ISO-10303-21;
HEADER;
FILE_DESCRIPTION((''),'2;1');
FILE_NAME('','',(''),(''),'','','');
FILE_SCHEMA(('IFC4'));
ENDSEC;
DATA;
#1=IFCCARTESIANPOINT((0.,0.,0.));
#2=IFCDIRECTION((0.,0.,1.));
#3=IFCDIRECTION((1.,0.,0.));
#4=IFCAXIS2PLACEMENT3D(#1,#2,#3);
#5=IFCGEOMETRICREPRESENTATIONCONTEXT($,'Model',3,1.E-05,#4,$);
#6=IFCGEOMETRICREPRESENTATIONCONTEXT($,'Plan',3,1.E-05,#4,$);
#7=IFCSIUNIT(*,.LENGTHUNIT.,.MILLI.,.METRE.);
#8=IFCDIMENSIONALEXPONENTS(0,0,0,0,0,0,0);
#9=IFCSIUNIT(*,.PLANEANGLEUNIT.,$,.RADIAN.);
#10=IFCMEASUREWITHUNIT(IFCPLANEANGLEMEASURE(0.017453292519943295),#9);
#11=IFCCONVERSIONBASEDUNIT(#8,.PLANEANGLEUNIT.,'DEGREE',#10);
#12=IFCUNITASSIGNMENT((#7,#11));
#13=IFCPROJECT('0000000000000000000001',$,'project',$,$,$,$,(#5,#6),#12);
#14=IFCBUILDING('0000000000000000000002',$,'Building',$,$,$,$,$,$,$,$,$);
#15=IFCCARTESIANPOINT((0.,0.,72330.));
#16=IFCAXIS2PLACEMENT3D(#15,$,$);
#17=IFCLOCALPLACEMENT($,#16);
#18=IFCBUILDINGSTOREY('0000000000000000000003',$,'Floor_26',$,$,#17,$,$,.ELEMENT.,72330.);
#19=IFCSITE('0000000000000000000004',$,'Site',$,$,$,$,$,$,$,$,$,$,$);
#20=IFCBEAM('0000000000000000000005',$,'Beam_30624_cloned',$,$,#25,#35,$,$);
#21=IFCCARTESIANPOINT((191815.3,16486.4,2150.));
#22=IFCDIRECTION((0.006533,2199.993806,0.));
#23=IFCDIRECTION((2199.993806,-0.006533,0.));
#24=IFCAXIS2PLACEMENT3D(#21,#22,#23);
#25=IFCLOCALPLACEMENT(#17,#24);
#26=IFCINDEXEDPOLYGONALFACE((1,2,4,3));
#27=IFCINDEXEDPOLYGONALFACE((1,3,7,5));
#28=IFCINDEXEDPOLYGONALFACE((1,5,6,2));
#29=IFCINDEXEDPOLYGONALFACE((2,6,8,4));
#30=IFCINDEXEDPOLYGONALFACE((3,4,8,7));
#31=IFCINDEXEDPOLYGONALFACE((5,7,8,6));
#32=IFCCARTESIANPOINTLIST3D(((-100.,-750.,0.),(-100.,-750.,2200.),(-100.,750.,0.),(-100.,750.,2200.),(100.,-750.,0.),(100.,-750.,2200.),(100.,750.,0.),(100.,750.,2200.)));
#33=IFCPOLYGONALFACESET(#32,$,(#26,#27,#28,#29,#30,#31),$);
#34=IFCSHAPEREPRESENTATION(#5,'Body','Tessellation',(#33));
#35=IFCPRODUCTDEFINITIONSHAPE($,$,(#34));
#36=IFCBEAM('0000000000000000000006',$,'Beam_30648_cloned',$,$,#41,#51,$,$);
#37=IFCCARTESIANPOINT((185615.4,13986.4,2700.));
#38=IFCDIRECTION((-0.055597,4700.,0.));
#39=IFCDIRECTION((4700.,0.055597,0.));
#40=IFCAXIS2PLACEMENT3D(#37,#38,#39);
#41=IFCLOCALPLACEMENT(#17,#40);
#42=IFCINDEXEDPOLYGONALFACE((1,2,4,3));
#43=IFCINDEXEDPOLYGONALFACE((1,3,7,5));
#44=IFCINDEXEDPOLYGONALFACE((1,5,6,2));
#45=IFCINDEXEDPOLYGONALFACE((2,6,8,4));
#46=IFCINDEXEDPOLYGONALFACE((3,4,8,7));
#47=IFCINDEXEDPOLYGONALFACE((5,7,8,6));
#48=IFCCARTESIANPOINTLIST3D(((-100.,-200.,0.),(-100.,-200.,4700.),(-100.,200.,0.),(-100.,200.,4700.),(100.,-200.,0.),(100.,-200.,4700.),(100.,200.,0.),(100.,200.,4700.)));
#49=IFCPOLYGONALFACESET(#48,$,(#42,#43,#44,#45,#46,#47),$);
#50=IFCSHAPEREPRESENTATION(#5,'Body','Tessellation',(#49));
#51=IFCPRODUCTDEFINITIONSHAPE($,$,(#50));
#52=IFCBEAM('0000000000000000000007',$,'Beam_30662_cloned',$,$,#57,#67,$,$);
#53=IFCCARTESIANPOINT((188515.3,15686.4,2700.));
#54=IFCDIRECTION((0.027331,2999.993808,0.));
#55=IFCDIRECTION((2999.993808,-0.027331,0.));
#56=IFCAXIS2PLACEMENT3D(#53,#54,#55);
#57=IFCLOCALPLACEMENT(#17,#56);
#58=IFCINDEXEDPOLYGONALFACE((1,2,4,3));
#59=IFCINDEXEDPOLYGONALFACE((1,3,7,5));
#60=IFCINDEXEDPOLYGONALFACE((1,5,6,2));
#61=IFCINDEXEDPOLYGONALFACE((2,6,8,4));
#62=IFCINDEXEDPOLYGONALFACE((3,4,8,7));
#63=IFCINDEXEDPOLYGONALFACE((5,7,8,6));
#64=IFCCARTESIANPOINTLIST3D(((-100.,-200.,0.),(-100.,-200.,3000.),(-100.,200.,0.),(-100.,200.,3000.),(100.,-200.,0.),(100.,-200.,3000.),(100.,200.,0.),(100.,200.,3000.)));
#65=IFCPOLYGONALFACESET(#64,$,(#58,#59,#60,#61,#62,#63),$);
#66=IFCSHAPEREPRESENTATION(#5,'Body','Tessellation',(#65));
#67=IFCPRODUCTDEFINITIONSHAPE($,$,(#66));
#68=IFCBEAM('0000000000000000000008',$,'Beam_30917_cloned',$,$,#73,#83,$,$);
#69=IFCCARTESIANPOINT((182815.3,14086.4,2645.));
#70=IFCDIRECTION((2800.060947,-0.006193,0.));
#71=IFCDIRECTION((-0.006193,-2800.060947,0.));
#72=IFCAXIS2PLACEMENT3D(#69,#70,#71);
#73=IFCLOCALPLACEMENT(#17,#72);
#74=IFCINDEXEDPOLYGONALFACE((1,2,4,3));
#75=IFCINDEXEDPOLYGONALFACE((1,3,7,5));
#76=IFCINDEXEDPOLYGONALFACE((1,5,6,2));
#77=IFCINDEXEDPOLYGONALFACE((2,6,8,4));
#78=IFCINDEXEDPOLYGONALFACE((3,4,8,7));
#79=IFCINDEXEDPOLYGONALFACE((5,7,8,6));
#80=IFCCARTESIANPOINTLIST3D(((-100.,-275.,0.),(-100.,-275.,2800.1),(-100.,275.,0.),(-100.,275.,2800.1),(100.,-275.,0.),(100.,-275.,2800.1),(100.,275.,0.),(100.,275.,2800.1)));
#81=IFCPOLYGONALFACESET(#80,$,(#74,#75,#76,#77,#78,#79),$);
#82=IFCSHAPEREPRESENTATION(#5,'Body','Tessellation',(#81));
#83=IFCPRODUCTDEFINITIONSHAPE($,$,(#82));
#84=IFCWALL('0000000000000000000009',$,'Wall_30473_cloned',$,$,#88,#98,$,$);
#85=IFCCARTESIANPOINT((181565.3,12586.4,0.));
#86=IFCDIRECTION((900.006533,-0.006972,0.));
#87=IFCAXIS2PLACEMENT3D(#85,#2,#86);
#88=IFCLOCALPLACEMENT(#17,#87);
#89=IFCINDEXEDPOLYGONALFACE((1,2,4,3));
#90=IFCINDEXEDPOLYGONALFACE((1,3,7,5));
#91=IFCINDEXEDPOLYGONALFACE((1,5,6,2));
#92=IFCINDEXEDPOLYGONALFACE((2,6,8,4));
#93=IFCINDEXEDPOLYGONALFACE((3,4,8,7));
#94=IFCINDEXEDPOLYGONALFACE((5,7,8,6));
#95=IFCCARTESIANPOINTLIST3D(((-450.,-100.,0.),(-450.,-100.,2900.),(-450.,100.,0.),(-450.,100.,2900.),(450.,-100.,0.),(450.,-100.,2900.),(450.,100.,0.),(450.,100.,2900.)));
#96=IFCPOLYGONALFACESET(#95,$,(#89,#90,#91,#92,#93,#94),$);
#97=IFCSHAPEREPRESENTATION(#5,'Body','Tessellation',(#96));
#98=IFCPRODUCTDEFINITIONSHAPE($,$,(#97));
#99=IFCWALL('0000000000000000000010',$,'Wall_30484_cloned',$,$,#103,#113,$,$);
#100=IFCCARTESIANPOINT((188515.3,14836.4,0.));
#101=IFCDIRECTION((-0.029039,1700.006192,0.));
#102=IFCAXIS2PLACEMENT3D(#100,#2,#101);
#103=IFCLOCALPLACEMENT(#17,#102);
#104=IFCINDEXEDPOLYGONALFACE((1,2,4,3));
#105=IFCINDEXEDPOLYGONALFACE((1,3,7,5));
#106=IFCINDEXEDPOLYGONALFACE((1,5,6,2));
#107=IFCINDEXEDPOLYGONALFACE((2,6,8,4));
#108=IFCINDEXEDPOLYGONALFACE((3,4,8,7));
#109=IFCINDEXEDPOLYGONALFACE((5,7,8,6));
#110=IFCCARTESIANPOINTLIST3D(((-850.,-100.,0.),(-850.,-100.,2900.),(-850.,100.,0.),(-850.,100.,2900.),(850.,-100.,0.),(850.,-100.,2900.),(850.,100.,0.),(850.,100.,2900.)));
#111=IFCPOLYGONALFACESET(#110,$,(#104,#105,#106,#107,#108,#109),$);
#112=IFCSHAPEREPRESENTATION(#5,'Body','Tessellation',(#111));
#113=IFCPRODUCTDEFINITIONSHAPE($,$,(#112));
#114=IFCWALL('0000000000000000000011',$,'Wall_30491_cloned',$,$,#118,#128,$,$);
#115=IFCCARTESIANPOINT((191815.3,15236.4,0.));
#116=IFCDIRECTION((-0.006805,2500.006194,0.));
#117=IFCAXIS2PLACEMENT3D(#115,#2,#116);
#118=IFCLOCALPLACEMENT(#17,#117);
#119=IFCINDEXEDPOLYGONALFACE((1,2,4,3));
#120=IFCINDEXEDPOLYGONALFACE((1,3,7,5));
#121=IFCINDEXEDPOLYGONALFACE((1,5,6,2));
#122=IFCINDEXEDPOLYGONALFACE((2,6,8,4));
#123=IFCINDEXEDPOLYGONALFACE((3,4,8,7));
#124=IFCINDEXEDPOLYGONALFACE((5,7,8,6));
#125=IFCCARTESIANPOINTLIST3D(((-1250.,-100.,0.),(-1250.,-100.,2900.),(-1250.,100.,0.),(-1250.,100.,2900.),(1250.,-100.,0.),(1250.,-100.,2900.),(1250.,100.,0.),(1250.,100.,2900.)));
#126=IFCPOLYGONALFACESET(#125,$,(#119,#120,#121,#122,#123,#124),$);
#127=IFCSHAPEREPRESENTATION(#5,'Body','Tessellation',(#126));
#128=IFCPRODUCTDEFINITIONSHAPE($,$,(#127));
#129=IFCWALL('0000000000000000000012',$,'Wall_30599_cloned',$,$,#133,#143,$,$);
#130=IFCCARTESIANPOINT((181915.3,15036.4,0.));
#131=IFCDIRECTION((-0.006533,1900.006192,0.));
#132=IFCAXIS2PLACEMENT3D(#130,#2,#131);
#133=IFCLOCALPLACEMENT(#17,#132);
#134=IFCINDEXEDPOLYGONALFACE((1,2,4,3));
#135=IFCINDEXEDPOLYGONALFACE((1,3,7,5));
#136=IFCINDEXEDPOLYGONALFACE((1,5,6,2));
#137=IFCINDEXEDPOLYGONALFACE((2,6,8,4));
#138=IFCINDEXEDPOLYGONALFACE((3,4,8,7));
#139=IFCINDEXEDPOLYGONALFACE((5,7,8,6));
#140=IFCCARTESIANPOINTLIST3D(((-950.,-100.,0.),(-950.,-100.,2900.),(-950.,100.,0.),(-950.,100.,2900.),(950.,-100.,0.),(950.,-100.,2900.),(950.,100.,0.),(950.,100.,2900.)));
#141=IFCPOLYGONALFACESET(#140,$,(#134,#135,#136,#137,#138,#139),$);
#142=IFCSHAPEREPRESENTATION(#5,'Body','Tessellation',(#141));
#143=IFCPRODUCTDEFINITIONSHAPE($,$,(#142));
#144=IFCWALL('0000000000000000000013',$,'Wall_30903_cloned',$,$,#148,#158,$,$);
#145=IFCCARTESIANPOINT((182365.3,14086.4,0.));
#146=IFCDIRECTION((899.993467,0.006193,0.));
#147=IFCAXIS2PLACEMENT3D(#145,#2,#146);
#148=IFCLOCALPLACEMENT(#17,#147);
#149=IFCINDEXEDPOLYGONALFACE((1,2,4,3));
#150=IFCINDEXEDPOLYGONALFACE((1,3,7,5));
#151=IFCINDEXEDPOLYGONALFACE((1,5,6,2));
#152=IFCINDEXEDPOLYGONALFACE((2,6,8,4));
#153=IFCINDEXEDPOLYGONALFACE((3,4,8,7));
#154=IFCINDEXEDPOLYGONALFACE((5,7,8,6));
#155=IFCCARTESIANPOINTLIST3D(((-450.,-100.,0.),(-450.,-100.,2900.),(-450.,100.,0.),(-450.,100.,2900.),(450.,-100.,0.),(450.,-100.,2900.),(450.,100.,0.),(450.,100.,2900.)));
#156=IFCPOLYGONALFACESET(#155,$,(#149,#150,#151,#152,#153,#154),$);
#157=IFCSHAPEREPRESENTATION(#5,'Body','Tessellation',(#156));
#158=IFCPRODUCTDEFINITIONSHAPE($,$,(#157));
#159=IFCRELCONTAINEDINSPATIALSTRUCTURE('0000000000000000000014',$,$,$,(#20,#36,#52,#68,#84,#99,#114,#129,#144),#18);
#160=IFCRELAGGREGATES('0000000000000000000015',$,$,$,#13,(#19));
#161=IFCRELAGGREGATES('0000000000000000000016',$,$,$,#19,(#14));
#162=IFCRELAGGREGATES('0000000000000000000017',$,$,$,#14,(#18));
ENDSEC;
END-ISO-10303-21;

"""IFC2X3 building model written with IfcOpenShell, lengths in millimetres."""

from ifc_helpers import new_model, entity, si_unit, converted_unit, frame, origin_with_axes, origin_2d, place, context, project, spatial, rectangle, extrude, source, transform, mapped, element, save


model = new_model("IFC2X3")

# Units and contexts
model_context = context("Model", 3, precision=1e-05, world=origin_with_axes())
plan_context = context("Plan", 3, precision=1e-05, world=origin_with_axes())
ifc_project = project(units=[si_unit("LENGTHUNIT", "METRE", prefix="MILLI"), converted_unit("PLANEANGLEUNIT", "DEGREE", entity("IfcPlaneAngleMeasure", 0.017453292519943295), si_unit("PLANEANGLEUNIT", "RADIAN"), dimensions=[0, 0, 0, 0, 0, 0, 0])], contexts=[model_context, plan_context])

# Site, building, storey
site = spatial("IfcSite", under=ifc_project, Name="Site")
building = spatial("IfcBuilding", under=site, Name="Building")
storey_placement = place(None, frame((0.0, 0.0, 72330.0)))
storey = spatial("IfcBuildingStorey", under=building, at=storey_placement, Name="Floor_26", CompositionType="ELEMENT", Elevation=72330.0)

# Beams
shared_shape_1 = source(origin_with_axes(), model_context, "Body", "SweptSolid", [
    extrude(rectangle(XDim=200.0, YDim=1500.0, at=origin_2d()), origin_with_axes(), (0.0, 0.0, 1.0), 2200.0),
])
beam_1_placement = place(storey_placement, frame((191815.3, 16486.4, 2150.0), z_axis=(0.006533, 2199.993806, 0.0), x_axis=(2199.993806, -0.006533, 0.0)))
element("IfcBeam", 1, at=beam_1_placement, inside=storey, Name="Beam_30624_cloned", context=model_context, shape_type="MappedRepresentation", body=[
    mapped(shared_shape_1, transform((0.0, 0.0, 0.0), x_axis=(1.0, 0.0, 0.0), y_axis=(0.0, 1.0, 0.0), z_axis=(0.0, 0.0, 1.0), scale=1.0)),
])
shared_shape_2 = source(origin_with_axes(), model_context, "Body", "SweptSolid", [
    extrude(rectangle(XDim=200.0, YDim=400.0, at=origin_2d()), origin_with_axes(), (0.0, 0.0, 1.0), 4700.0),
])
beam_2_placement = place(storey_placement, frame((185615.4, 13986.4, 2700.0), z_axis=(-0.055597, 4700.0, 0.0), x_axis=(4700.0, 0.055597, 0.0)))
element("IfcBeam", 2, at=beam_2_placement, inside=storey, Name="Beam_30648_cloned", context=model_context, shape_type="MappedRepresentation", body=[
    mapped(shared_shape_2, transform((0.0, 0.0, 0.0), x_axis=(1.0, 0.0, 0.0), y_axis=(0.0, 1.0, 0.0), z_axis=(0.0, 0.0, 1.0), scale=1.0)),
])
shared_shape_3 = source(origin_with_axes(), model_context, "Body", "SweptSolid", [
    extrude(rectangle(XDim=200.0, YDim=400.0, at=origin_2d()), origin_with_axes(), (0.0, 0.0, 1.0), 3000.0),
])
beam_3_placement = place(storey_placement, frame((188515.3, 15686.4, 2700.0), z_axis=(0.027331, 2999.993808, 0.0), x_axis=(2999.993808, -0.027331, 0.0)))
element("IfcBeam", 3, at=beam_3_placement, inside=storey, Name="Beam_30662_cloned", context=model_context, shape_type="MappedRepresentation", body=[
    mapped(shared_shape_3, transform((0.0, 0.0, 0.0), x_axis=(1.0, 0.0, 0.0), y_axis=(0.0, 1.0, 0.0), z_axis=(0.0, 0.0, 1.0), scale=1.0)),
])
shared_shape_4 = source(origin_with_axes(), model_context, "Body", "SweptSolid", [
    extrude(rectangle(XDim=200.0, YDim=550.0, at=origin_2d()), origin_with_axes(), (0.0, 0.0, 1.0), 2800.1),
])
beam_4_placement = place(storey_placement, frame((182815.3, 14086.4, 2645.0), z_axis=(2800.060947, -0.006193, 0.0), x_axis=(-0.006193, -2800.060947, 0.0)))
element("IfcBeam", 4, at=beam_4_placement, inside=storey, Name="Beam_30917_cloned", context=model_context, shape_type="MappedRepresentation", body=[
    mapped(shared_shape_4, transform((0.0, 0.0, 0.0), x_axis=(1.0, 0.0, 0.0), y_axis=(0.0, 1.0, 0.0), z_axis=(0.0, 0.0, 1.0), scale=1.0)),
])

# Walls
shared_shape_5 = source(origin_with_axes(), model_context, "Body", "SweptSolid", [
    extrude(rectangle(XDim=900.0, YDim=200.0, at=origin_2d()), origin_with_axes(), (0.0, 0.0, 1.0), 2900.0),
])
wall_1_placement = place(storey_placement, frame((181565.3, 12586.4, 0.0), z_axis=(0.0, 0.0, 1.0), x_axis=(900.006533, -0.006972, 0.0)))
element("IfcWall", 5, at=wall_1_placement, inside=storey, Name="Wall_30473_cloned", context=model_context, shape_type="MappedRepresentation", body=[
    mapped(shared_shape_5, transform((0.0, 0.0, 0.0), x_axis=(1.0, 0.0, 0.0), y_axis=(0.0, 1.0, 0.0), z_axis=(0.0, 0.0, 1.0), scale=1.0)),
])
shared_shape_6 = source(origin_with_axes(), model_context, "Body", "SweptSolid", [
    extrude(rectangle(XDim=1700.0, YDim=200.0, at=origin_2d()), origin_with_axes(), (0.0, 0.0, 1.0), 2900.0),
])
wall_2_placement = place(storey_placement, frame((188515.3, 14836.4, 0.0), z_axis=(0.0, 0.0, 1.0), x_axis=(-0.029039, 1700.006192, 0.0)))
element("IfcWall", 6, at=wall_2_placement, inside=storey, Name="Wall_30484_cloned", context=model_context, shape_type="MappedRepresentation", body=[
    mapped(shared_shape_6, transform((0.0, 0.0, 0.0), x_axis=(1.0, 0.0, 0.0), y_axis=(0.0, 1.0, 0.0), z_axis=(0.0, 0.0, 1.0), scale=1.0)),
])
shared_shape_7 = source(origin_with_axes(), model_context, "Body", "SweptSolid", [
    extrude(rectangle(XDim=2500.0, YDim=200.0, at=origin_2d()), origin_with_axes(), (0.0, 0.0, 1.0), 2900.0),
])
wall_3_placement = place(storey_placement, frame((191815.3, 15236.4, 0.0), z_axis=(0.0, 0.0, 1.0), x_axis=(-0.006805, 2500.006194, 0.0)))
element("IfcWall", 7, at=wall_3_placement, inside=storey, Name="Wall_30491_cloned", context=model_context, shape_type="MappedRepresentation", body=[
    mapped(shared_shape_7, transform((0.0, 0.0, 0.0), x_axis=(1.0, 0.0, 0.0), y_axis=(0.0, 1.0, 0.0), z_axis=(0.0, 0.0, 1.0), scale=1.0)),
])
shared_shape_8 = source(origin_with_axes(), model_context, "Body", "SweptSolid", [
    extrude(rectangle(XDim=1900.0, YDim=200.0, at=origin_2d()), origin_with_axes(), (0.0, 0.0, 1.0), 2900.0),
])
wall_4_placement = place(storey_placement, frame((181915.3, 15036.4, 0.0), z_axis=(0.0, 0.0, 1.0), x_axis=(-0.006533, 1900.006192, 0.0)))
element("IfcWall", 8, at=wall_4_placement, inside=storey, Name="Wall_30599_cloned", context=model_context, shape_type="MappedRepresentation", body=[
    mapped(shared_shape_8, transform((0.0, 0.0, 0.0), x_axis=(1.0, 0.0, 0.0), y_axis=(0.0, 1.0, 0.0), z_axis=(0.0, 0.0, 1.0), scale=1.0)),
])
shared_shape_9 = source(origin_with_axes(), model_context, "Body", "SweptSolid", [
    extrude(rectangle(XDim=900.0, YDim=200.0, at=origin_2d()), origin_with_axes(), (0.0, 0.0, 1.0), 2900.0),
])
wall_5_placement = place(storey_placement, frame((182365.3, 14086.4, 0.0), z_axis=(0.0, 0.0, 1.0), x_axis=(899.993467, 0.006193, 0.0)))
element("IfcWall", 9, at=wall_5_placement, inside=storey, Name="Wall_30903_cloned", context=model_context, shape_type="MappedRepresentation", body=[
    mapped(shared_shape_9, transform((0.0, 0.0, 0.0), x_axis=(1.0, 0.0, 0.0), y_axis=(0.0, 1.0, 0.0), z_axis=(0.0, 0.0, 1.0), scale=1.0)),
])

save(model, "model.ifc")
